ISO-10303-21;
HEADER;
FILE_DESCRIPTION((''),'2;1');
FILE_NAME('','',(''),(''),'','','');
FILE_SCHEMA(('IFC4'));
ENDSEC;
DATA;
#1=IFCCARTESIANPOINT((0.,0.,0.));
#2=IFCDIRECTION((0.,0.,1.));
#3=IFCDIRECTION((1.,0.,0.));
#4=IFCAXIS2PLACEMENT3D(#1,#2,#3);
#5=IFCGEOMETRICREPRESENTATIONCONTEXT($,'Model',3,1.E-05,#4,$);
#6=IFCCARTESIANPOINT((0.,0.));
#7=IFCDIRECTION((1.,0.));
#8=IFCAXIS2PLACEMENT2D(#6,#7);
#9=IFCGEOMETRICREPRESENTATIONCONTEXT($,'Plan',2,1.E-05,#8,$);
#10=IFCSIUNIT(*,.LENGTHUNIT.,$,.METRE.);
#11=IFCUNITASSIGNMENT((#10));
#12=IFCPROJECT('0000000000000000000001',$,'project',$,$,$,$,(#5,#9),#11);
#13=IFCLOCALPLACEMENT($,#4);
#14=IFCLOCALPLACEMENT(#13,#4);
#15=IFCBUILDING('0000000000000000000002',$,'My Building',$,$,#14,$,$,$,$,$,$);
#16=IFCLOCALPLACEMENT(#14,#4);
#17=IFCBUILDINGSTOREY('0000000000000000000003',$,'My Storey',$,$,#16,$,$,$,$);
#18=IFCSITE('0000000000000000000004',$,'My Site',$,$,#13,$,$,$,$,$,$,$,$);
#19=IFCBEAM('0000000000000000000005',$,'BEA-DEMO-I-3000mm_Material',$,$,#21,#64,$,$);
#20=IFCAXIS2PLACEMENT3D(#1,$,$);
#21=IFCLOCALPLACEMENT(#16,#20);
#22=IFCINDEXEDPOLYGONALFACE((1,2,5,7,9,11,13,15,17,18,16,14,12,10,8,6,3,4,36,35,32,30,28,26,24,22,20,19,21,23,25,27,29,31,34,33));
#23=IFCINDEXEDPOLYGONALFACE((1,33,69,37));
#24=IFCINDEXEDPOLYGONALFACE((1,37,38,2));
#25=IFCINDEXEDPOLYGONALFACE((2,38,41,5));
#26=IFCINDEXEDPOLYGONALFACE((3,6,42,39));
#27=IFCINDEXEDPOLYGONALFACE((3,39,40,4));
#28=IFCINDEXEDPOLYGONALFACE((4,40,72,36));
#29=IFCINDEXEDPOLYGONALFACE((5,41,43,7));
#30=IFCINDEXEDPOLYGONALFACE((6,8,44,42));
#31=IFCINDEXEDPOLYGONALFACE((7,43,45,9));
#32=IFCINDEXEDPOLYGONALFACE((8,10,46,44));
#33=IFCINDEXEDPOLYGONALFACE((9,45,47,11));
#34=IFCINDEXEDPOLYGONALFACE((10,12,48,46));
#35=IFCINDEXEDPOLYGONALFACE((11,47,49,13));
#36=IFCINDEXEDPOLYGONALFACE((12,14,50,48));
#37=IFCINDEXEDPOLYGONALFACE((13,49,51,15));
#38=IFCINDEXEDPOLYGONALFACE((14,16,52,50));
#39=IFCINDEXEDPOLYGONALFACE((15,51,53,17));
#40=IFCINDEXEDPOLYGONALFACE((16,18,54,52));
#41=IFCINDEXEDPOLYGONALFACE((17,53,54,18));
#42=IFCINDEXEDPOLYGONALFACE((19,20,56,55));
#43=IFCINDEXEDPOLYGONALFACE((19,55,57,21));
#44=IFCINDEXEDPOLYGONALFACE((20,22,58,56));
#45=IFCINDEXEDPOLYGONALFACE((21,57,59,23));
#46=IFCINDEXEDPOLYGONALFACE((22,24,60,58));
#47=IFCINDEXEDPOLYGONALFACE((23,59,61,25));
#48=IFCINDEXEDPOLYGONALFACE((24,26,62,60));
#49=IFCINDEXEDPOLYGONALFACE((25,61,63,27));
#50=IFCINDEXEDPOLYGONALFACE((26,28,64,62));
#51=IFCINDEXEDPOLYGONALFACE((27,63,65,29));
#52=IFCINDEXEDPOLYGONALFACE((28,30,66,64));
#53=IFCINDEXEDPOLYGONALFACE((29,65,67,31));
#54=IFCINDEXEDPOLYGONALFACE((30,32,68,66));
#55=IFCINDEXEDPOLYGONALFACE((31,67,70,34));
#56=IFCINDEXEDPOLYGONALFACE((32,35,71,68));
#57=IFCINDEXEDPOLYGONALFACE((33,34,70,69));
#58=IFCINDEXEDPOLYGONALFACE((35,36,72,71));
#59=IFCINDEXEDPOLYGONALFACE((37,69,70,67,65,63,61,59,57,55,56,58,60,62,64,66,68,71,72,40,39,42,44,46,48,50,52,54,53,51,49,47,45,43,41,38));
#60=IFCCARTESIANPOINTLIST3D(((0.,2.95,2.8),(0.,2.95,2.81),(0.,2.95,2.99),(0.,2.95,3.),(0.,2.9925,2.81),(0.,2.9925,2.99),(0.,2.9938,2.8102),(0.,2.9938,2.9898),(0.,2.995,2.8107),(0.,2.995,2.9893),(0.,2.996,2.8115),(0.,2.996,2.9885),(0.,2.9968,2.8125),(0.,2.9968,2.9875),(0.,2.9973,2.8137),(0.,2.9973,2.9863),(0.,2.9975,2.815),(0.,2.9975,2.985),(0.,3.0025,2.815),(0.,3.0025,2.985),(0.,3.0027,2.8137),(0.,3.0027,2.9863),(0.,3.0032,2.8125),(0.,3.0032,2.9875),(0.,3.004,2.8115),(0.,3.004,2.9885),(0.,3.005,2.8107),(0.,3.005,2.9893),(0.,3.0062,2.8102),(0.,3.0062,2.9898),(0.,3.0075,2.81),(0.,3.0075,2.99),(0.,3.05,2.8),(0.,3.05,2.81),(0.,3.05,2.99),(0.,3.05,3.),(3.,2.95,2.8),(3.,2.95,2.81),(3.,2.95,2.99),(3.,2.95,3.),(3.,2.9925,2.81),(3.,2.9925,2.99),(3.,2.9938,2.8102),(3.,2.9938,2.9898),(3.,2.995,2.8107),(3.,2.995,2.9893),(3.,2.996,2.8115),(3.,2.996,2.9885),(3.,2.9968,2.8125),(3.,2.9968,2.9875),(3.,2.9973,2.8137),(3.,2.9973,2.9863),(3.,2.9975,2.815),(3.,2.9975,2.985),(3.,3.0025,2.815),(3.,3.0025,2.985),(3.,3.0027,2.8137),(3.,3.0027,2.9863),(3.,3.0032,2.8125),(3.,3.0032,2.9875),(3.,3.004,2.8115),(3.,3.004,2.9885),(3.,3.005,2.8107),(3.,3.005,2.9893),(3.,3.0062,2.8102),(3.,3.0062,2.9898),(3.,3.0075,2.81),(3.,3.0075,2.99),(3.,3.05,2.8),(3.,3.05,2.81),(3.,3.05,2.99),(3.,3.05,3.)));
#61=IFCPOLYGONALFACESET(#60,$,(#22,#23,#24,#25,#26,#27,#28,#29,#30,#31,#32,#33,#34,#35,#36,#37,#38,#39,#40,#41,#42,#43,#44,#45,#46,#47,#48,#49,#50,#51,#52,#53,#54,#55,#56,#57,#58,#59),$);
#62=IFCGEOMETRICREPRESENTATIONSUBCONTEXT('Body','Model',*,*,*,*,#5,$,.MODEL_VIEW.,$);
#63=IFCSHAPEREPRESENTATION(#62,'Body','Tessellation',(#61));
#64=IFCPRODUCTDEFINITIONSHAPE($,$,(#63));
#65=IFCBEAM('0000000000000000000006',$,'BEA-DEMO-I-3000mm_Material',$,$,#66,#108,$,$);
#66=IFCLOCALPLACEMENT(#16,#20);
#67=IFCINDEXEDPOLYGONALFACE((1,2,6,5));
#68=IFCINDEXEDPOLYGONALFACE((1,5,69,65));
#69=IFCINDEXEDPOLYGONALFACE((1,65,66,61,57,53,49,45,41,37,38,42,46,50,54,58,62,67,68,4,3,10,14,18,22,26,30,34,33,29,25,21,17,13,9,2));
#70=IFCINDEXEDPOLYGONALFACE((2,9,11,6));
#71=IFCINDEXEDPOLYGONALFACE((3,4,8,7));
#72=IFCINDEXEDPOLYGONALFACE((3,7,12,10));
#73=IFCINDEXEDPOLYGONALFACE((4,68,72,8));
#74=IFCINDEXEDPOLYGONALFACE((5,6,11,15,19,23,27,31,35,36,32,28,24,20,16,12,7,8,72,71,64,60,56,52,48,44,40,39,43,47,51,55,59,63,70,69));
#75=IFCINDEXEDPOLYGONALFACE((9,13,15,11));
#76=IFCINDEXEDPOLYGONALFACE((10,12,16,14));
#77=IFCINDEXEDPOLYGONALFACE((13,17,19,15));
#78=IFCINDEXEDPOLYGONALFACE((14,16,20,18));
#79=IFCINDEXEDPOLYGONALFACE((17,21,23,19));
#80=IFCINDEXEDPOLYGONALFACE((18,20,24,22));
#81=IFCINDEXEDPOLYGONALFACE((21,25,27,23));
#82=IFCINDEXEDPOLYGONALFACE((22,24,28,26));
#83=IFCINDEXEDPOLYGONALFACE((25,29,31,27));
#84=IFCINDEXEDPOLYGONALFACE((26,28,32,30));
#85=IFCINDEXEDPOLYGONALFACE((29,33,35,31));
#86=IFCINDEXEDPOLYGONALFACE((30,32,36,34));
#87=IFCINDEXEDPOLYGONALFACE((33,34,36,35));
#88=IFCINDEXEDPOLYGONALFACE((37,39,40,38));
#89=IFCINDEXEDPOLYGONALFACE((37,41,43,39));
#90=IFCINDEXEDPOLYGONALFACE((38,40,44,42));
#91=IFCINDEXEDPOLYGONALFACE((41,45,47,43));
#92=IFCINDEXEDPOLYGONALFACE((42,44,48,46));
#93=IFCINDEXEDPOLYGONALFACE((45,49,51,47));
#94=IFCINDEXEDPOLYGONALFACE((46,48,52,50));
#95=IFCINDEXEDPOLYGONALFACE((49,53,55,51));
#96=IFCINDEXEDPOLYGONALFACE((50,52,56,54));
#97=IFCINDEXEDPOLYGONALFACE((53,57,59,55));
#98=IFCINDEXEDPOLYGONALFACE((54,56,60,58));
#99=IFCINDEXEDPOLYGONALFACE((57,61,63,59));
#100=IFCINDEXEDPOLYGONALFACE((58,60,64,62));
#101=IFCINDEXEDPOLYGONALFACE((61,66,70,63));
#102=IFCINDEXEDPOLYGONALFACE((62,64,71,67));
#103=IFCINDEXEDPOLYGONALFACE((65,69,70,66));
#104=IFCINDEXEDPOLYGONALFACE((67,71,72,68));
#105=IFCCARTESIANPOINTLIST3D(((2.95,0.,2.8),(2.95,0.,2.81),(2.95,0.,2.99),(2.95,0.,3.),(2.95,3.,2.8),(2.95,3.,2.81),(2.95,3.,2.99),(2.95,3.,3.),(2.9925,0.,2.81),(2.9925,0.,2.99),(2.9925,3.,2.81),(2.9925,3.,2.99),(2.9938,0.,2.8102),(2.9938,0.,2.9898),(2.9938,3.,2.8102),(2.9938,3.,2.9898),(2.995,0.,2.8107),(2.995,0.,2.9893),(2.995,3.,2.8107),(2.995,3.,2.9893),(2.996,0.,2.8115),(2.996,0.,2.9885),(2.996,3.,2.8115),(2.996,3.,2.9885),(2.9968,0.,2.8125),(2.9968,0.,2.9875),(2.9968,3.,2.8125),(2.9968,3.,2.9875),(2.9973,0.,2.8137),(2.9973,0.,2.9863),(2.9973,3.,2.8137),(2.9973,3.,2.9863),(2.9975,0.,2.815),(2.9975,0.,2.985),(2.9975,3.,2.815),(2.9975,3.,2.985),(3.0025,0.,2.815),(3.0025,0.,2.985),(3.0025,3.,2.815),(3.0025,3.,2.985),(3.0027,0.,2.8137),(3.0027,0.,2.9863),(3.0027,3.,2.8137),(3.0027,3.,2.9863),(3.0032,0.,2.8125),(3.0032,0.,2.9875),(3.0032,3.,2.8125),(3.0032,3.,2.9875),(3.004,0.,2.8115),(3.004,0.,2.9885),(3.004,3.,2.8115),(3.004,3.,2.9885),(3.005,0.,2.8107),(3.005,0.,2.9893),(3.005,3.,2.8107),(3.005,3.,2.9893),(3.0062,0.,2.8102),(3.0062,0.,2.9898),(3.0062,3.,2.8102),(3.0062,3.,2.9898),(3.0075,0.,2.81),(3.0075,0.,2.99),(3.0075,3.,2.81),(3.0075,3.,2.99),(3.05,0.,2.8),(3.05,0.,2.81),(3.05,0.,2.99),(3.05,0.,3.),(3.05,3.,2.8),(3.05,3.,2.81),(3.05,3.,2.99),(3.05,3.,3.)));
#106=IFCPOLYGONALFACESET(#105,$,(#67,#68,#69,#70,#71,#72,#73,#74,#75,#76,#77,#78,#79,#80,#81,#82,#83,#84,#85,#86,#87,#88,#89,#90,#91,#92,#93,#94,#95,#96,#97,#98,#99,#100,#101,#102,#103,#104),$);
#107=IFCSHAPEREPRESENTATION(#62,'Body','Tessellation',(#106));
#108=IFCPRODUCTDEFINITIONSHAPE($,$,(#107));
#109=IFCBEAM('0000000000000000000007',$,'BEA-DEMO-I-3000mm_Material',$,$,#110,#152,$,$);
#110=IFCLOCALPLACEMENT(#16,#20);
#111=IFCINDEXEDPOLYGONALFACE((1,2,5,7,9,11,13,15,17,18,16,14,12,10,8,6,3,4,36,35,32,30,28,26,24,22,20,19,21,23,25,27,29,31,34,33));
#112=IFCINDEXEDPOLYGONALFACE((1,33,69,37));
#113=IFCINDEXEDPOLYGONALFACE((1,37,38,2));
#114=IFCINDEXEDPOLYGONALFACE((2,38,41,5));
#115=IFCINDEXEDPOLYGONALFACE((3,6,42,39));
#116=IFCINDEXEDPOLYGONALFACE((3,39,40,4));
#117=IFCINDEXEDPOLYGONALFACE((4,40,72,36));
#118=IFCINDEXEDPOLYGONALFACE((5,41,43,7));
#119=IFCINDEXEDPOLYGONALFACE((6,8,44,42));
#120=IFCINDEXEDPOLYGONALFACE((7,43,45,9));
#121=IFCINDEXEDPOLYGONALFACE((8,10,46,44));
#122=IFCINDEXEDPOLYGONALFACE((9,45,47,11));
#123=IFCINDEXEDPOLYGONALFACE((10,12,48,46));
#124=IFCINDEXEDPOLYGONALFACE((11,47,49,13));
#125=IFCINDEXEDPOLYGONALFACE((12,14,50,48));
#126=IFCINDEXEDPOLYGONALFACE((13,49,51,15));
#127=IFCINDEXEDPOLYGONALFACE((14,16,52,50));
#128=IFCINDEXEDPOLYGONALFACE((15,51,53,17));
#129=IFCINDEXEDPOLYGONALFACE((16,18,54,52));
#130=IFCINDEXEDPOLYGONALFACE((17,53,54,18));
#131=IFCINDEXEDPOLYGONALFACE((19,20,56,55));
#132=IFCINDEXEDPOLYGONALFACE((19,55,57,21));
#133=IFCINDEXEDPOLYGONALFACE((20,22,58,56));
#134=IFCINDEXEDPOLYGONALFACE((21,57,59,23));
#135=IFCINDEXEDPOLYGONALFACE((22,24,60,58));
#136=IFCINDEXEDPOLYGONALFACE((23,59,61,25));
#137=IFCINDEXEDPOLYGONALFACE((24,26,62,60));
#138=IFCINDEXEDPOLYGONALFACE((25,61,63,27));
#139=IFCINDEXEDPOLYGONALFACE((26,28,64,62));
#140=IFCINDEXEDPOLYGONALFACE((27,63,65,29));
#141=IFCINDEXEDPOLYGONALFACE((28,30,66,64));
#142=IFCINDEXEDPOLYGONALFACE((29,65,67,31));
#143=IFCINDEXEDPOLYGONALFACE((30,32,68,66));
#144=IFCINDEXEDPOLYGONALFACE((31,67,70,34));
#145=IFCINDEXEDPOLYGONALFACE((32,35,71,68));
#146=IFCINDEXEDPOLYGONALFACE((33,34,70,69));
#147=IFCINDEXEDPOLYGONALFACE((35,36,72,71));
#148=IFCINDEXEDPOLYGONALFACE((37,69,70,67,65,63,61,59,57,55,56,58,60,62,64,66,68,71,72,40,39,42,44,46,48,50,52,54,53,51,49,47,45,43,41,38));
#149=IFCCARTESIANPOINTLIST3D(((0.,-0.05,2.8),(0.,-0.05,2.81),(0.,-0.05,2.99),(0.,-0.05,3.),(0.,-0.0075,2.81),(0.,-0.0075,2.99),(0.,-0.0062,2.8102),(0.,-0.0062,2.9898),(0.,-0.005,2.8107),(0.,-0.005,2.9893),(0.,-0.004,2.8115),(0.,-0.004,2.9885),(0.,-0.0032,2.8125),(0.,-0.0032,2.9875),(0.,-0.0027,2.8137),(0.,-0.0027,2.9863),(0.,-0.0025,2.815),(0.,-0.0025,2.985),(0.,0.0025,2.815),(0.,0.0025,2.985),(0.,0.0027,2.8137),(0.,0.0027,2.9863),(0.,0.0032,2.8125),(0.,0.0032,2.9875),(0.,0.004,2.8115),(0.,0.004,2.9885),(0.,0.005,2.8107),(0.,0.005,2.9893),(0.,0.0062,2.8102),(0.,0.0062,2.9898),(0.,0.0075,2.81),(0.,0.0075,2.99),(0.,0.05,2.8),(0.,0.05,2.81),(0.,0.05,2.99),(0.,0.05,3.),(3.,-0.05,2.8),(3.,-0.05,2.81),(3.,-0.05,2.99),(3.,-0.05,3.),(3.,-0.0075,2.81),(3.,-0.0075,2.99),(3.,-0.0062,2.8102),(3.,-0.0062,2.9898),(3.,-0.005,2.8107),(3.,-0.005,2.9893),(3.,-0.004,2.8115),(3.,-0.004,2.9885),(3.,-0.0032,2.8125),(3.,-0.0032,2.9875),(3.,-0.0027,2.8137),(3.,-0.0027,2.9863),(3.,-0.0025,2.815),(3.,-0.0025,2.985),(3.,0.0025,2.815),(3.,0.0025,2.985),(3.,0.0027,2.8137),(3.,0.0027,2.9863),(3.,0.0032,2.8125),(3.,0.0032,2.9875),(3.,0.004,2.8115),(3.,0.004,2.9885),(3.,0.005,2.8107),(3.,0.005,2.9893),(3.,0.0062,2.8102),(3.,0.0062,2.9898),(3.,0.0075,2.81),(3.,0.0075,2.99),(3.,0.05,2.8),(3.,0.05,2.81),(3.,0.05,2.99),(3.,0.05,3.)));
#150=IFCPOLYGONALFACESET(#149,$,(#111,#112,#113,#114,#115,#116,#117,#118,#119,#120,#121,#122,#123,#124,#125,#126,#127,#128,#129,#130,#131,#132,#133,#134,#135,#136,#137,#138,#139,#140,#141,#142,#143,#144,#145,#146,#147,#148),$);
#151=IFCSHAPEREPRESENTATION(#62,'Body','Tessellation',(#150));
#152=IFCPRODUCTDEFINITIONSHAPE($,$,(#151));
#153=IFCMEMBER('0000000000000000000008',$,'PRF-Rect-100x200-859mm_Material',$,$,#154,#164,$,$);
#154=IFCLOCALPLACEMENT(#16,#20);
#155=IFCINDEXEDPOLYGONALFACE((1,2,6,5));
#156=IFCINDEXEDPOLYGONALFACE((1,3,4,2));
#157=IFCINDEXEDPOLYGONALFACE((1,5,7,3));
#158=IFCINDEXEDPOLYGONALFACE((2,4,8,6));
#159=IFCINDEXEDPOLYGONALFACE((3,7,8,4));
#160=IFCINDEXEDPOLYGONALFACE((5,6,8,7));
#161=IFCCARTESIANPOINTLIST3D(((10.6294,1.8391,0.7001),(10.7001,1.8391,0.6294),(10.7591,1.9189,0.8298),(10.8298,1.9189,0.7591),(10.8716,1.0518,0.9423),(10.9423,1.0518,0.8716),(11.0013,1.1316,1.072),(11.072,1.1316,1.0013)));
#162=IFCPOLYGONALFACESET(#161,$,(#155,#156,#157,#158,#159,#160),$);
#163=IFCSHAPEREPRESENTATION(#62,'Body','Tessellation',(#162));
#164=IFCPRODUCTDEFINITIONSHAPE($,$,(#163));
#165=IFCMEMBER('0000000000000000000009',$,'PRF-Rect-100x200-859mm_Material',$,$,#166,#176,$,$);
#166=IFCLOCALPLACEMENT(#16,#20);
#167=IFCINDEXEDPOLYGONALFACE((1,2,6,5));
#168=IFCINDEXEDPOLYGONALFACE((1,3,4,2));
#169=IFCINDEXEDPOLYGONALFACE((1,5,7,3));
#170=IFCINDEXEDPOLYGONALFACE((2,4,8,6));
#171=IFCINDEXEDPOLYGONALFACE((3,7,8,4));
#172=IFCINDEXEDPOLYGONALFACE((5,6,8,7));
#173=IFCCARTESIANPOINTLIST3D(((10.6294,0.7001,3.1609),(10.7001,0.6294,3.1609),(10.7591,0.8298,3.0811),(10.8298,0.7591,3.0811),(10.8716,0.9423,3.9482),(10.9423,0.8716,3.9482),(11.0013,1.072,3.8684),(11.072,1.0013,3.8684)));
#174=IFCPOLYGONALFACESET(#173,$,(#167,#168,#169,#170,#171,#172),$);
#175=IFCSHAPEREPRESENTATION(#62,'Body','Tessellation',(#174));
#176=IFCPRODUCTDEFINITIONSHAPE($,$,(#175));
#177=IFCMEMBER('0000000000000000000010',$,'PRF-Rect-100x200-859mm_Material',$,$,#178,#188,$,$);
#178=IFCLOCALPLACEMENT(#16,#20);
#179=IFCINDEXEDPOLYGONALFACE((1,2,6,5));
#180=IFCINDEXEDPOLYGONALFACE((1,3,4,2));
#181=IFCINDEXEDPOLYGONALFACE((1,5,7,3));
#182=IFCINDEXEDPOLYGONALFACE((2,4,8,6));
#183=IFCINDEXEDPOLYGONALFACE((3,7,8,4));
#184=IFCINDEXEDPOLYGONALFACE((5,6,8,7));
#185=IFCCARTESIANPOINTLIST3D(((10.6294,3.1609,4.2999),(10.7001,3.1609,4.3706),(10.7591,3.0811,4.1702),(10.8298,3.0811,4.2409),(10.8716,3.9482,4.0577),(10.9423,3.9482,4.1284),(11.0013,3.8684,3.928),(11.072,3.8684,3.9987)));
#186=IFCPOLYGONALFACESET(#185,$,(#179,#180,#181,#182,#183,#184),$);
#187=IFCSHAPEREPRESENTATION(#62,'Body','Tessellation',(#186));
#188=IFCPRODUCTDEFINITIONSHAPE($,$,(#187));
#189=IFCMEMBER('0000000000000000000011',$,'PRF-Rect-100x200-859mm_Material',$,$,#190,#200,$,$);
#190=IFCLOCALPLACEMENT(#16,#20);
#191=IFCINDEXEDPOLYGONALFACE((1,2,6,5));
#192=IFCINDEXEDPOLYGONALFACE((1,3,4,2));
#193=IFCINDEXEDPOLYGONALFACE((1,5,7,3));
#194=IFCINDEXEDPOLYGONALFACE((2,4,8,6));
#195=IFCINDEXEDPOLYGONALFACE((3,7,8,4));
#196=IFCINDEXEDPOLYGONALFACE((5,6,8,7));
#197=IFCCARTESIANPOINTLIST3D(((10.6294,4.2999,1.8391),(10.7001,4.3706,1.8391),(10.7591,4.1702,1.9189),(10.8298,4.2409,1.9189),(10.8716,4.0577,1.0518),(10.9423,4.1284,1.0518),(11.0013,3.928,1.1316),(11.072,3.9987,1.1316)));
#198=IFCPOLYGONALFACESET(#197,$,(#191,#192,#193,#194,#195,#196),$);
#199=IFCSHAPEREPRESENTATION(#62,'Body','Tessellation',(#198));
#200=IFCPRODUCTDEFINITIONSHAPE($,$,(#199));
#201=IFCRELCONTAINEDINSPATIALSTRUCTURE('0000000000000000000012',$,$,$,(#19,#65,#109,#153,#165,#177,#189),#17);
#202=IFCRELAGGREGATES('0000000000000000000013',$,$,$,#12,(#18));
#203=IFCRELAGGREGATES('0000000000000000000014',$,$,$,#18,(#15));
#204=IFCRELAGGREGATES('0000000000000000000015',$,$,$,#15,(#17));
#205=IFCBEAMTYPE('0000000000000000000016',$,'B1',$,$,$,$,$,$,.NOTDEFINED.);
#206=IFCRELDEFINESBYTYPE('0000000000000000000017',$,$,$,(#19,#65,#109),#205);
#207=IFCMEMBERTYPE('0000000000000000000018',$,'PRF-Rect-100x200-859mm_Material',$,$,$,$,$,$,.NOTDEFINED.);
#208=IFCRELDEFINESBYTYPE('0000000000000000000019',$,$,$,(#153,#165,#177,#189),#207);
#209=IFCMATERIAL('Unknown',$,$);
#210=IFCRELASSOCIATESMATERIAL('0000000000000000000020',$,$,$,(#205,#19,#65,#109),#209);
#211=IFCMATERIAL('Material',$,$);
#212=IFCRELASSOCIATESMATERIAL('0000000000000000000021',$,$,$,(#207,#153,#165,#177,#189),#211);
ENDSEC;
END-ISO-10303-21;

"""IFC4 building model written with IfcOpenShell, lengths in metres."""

from ifc_helpers import new_model, si_unit, frame, origin, origin_with_axes, origin_2d_with_axis, place, context, subcontext, project, spatial, rectangle, i_section, extrude, material, material_profile, profile_set, profile_usage, type_object, element, save


model = new_model("IFC4")

# Units and contexts
model_context = context("Model", 3, precision=1e-05, world=origin_with_axes())
plan_context = context("Plan", 2, precision=1e-05, world=origin_2d_with_axis())
body_context = subcontext(model_context, "Body", "Model", "MODEL_VIEW")
ifc_project = project(units=[si_unit("LENGTHUNIT", "METRE")], contexts=[model_context, plan_context])

# Site, building, storey
site_placement = place(None, origin_with_axes())
site = spatial("IfcSite", under=ifc_project, at=site_placement, Name="My Site")
building_placement = place(site_placement, origin_with_axes())
building = spatial("IfcBuilding", under=site, at=building_placement, Name="My Building")
storey_placement = place(building_placement, origin_with_axes())
storey = spatial("IfcBuildingStorey", under=building, at=storey_placement, Name="My Storey")

# Shared definitions
ifc_material_1 = material(Name="Unknown")

# Beams
ifc_material_profile_1 = material_profile(ifc_material_1, i_section(OverallWidth=0.1, OverallDepth=0.2, WebThickness=0.005, FlangeThickness=0.01, FilletRadius=0.005))
ifc_profile_set_1 = profile_set([ifc_material_profile_1])
beam_type = type_object("IfcBeamType", Name="B1", PredefinedType="NOTDEFINED", material=ifc_profile_set_1)
ifc_profile_usage_1 = profile_usage(ifc_profile_set_1, cardinal=8)
beam_1_placement = place(storey_placement, frame((0.0, 3.0, 3.0), z_axis=(1.0, 0.0, 0.0), x_axis=(0.0, 1.0, 0.0)))
element("IfcBeam", 1, at=beam_1_placement, inside=storey, type_object=beam_type, material=ifc_profile_usage_1, Name="BEA-DEMO-I-3000mm_Material", context=body_context, shape_type="SweptSolid", body=[
    extrude(i_section(OverallWidth=0.1, OverallDepth=0.2, WebThickness=0.005, FlangeThickness=0.01, FilletRadius=0.005), frame((0.0, -0.1, 0.0)), (0.0, 0.0, 1.0), 3.0),
])
ifc_profile_usage_2 = profile_usage(ifc_profile_set_1, cardinal=8)
beam_2_placement = place(storey_placement, frame((3.0, 3.0, 3.0), z_axis=(0.0, -1.0, 0.0), x_axis=(1.0, 0.0, 0.0)))
element("IfcBeam", 2, at=beam_2_placement, inside=storey, type_object=beam_type, material=ifc_profile_usage_2, Name="BEA-DEMO-I-3000mm_Material", context=body_context, shape_type="SweptSolid", body=[
    extrude(i_section(OverallWidth=0.1, OverallDepth=0.2, WebThickness=0.005, FlangeThickness=0.01, FilletRadius=0.005), frame((0.0, -0.1, 0.0)), (0.0, 0.0, 1.0), 3.0),
])
ifc_profile_usage_3 = profile_usage(ifc_profile_set_1, cardinal=8)
beam_3_placement = place(storey_placement, frame((3.0, 0.0, 3.0), z_axis=(-1.0, 0.0, 0.0), x_axis=(0.0, -1.0, 0.0)))
element("IfcBeam", 3, at=beam_3_placement, inside=storey, type_object=beam_type, material=ifc_profile_usage_3, Name="BEA-DEMO-I-3000mm_Material", context=body_context, shape_type="SweptSolid", body=[
    extrude(i_section(OverallWidth=0.1, OverallDepth=0.2, WebThickness=0.005, FlangeThickness=0.01, FilletRadius=0.005), frame((0.0, -0.1, 0.0)), (0.0, 0.0, 1.0), 3.0),
])

# Members
ifc_material_2 = material(Name="Material")
ifc_material_profile_2 = material_profile(ifc_material_2, rectangle(XDim=0.1, YDim=0.2))
ifc_profile_set_2 = profile_set([ifc_material_profile_2], Name="PRF-Rect-100x200-859mm_Material")
ifc_profile_usage_4 = profile_usage(ifc_profile_set_2, cardinal=5)
member_type_1 = type_object("IfcMemberType", Name="PRF-Rect-100x200-859mm_Material", PredefinedType="NOTDEFINED", material=ifc_profile_set_2)
member_1_placement = place(storey_placement, frame((10.7296, 1.879, 0.7296), z_axis=(0.282066, -0.916993, 0.282067), x_axis=(-0.707107, 0.0, 0.707107)))
element("IfcMember", 4, at=member_1_placement, inside=storey, type_object=member_type_1, material=ifc_profile_usage_4, Name="PRF-Rect-100x200-859mm_Material", context=body_context, shape_type="SweptSolid", body=[
    extrude(rectangle(XDim=0.1, YDim=0.2), origin(), (0.0, 0.0, 1.0), 0.8586),
])
ifc_profile_usage_5 = profile_usage(ifc_profile_set_2, cardinal=5)
member_2_placement = place(storey_placement, frame((10.7296, 0.7296, 3.121), z_axis=(0.282066, 0.282067, 0.916993), x_axis=(-0.707107, 0.707107, 0.0)))
element("IfcMember", 5, at=member_2_placement, inside=storey, type_object=member_type_1, material=ifc_profile_usage_5, Name="PRF-Rect-100x200-859mm_Material", context=body_context, shape_type="SweptSolid", body=[
    extrude(rectangle(XDim=0.1, YDim=0.2), origin(), (0.0, 0.0, 1.0), 0.8586),
])
ifc_profile_usage_6 = profile_usage(ifc_profile_set_2, cardinal=5)
member_3_placement = place(storey_placement, frame((10.7296, 3.121, 4.2704), z_axis=(0.282066, 0.916994, -0.282066), x_axis=(-0.707107, 0.0, -0.707107)))
element("IfcMember", 6, at=member_3_placement, inside=storey, type_object=member_type_1, material=ifc_profile_usage_6, Name="PRF-Rect-100x200-859mm_Material", context=body_context, shape_type="SweptSolid", body=[
    extrude(rectangle(XDim=0.1, YDim=0.2), origin(), (0.0, 0.0, 1.0), 0.8586),
])
ifc_profile_usage_7 = profile_usage(ifc_profile_set_2, cardinal=5)
member_4_placement = place(storey_placement, frame((10.7296, 4.2704, 1.879), z_axis=(0.282066, -0.282067, -0.916993), x_axis=(-0.707107, -0.707107, 0.0)))
element("IfcMember", 7, at=member_4_placement, inside=storey, type_object=member_type_1, material=ifc_profile_usage_7, Name="PRF-Rect-100x200-859mm_Material", context=body_context, shape_type="SweptSolid", body=[
    extrude(rectangle(XDim=0.1, YDim=0.2), origin(), (0.0, 0.0, 1.0), 0.8586),
])

save(model, "model.ifc")
